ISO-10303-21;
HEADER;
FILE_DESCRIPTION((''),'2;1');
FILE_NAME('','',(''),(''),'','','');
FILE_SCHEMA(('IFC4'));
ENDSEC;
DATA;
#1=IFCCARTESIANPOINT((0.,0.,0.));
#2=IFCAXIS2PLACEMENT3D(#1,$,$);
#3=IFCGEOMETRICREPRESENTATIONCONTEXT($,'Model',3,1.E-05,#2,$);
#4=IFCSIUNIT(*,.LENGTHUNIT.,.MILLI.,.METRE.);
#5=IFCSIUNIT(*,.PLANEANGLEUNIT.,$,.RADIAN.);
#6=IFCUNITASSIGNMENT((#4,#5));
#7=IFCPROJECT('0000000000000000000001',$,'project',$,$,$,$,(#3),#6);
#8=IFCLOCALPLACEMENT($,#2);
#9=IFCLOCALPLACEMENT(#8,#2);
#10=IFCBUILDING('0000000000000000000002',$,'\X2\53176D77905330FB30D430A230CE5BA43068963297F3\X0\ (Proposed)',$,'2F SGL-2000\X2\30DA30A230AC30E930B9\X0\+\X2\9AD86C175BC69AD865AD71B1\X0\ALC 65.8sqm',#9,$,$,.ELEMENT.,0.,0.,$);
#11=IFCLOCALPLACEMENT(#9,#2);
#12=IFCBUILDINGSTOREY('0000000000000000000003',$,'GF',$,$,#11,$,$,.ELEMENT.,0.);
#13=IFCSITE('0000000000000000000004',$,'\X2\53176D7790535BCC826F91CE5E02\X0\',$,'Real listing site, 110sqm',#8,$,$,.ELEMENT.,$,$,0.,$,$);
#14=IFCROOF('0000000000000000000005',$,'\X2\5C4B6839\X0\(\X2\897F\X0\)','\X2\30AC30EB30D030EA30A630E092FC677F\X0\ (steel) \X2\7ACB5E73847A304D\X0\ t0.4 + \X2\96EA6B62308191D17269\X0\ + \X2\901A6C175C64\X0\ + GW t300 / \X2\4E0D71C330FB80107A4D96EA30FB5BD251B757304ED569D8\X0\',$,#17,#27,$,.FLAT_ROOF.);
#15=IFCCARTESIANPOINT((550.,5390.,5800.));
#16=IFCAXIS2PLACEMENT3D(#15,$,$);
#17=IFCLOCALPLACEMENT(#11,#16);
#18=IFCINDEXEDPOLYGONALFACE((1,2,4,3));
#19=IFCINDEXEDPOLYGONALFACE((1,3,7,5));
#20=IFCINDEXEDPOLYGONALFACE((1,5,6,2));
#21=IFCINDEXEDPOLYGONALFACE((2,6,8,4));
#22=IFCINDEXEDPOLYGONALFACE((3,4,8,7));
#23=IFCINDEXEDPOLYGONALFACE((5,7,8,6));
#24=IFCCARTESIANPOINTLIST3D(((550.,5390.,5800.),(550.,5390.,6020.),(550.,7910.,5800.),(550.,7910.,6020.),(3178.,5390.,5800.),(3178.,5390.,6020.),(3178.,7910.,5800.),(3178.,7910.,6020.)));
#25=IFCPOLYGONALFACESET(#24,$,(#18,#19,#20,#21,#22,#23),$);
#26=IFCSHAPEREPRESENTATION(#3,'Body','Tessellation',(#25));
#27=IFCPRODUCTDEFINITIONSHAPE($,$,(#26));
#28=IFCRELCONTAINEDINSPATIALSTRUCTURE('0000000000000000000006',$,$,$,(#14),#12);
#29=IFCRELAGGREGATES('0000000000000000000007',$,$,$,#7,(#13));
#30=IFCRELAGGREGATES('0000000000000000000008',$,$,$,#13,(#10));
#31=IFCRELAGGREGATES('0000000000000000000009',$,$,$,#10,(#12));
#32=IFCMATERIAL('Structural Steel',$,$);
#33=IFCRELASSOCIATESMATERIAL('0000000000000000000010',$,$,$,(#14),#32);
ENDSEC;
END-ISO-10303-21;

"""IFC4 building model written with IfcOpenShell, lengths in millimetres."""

from ifc_helpers import new_model, si_unit, frame, frame_2d, origin, place, context, project, spatial, rectangle, extrude, material, element, save


model = new_model("IFC4")

# Units and contexts
model_context = context("Model", 3, precision=1e-05, world=origin())
ifc_project = project(units=[si_unit("LENGTHUNIT", "METRE", prefix="MILLI"), si_unit("PLANEANGLEUNIT", "RADIAN")], contexts=[model_context])

# Site, building, storey
site_placement = place(None, origin())
site = spatial("IfcSite", under=ifc_project, at=site_placement, Name="北海道富良野市", ObjectType="Real listing site, 110sqm", CompositionType="ELEMENT", RefElevation=0.0)
building_placement = place(site_placement, origin())
building = spatial("IfcBuilding", under=site, at=building_placement, Name="北海道・ピアノ室と防音 (Proposed)", ObjectType="2F SGL-2000ペアガラス+高気密高断熱ALC 65.8sqm", CompositionType="ELEMENT", ElevationOfRefHeight=0.0, ElevationOfTerrain=0.0)
storey_placement = place(building_placement, origin())
storey = spatial("IfcBuildingStorey", under=building, at=storey_placement, Name="GF", CompositionType="ELEMENT", Elevation=0.0)

# Roof
ifc_material_1 = material(Name="Structural Steel")
for number, where, name in (
    (1, (550.0, 5390.0, 5800.0), "屋根(西)"),
):
    element("IfcRoof", number, at=place(storey_placement, frame(where)), inside=storey, material=ifc_material_1, Name=name, Description="ガルバリウム鋼板 (steel) 立平葺き t0.4 + 雪止め金物 + 通気層 + GW t300 / 不燃・耐積雪・寒冷地仕様", PredefinedType="FLAT_ROOF", context=model_context, shape_type="SweptSolid", body=[
        extrude(rectangle(XDim=2628.0, YDim=2520.0, at=frame_2d((1314.0, 1260.0))), frame((550.0, 5390.0, 5800.0)), (0.0, 0.0, 1.0), 220.0),
    ])

save(model, "model.ifc")
